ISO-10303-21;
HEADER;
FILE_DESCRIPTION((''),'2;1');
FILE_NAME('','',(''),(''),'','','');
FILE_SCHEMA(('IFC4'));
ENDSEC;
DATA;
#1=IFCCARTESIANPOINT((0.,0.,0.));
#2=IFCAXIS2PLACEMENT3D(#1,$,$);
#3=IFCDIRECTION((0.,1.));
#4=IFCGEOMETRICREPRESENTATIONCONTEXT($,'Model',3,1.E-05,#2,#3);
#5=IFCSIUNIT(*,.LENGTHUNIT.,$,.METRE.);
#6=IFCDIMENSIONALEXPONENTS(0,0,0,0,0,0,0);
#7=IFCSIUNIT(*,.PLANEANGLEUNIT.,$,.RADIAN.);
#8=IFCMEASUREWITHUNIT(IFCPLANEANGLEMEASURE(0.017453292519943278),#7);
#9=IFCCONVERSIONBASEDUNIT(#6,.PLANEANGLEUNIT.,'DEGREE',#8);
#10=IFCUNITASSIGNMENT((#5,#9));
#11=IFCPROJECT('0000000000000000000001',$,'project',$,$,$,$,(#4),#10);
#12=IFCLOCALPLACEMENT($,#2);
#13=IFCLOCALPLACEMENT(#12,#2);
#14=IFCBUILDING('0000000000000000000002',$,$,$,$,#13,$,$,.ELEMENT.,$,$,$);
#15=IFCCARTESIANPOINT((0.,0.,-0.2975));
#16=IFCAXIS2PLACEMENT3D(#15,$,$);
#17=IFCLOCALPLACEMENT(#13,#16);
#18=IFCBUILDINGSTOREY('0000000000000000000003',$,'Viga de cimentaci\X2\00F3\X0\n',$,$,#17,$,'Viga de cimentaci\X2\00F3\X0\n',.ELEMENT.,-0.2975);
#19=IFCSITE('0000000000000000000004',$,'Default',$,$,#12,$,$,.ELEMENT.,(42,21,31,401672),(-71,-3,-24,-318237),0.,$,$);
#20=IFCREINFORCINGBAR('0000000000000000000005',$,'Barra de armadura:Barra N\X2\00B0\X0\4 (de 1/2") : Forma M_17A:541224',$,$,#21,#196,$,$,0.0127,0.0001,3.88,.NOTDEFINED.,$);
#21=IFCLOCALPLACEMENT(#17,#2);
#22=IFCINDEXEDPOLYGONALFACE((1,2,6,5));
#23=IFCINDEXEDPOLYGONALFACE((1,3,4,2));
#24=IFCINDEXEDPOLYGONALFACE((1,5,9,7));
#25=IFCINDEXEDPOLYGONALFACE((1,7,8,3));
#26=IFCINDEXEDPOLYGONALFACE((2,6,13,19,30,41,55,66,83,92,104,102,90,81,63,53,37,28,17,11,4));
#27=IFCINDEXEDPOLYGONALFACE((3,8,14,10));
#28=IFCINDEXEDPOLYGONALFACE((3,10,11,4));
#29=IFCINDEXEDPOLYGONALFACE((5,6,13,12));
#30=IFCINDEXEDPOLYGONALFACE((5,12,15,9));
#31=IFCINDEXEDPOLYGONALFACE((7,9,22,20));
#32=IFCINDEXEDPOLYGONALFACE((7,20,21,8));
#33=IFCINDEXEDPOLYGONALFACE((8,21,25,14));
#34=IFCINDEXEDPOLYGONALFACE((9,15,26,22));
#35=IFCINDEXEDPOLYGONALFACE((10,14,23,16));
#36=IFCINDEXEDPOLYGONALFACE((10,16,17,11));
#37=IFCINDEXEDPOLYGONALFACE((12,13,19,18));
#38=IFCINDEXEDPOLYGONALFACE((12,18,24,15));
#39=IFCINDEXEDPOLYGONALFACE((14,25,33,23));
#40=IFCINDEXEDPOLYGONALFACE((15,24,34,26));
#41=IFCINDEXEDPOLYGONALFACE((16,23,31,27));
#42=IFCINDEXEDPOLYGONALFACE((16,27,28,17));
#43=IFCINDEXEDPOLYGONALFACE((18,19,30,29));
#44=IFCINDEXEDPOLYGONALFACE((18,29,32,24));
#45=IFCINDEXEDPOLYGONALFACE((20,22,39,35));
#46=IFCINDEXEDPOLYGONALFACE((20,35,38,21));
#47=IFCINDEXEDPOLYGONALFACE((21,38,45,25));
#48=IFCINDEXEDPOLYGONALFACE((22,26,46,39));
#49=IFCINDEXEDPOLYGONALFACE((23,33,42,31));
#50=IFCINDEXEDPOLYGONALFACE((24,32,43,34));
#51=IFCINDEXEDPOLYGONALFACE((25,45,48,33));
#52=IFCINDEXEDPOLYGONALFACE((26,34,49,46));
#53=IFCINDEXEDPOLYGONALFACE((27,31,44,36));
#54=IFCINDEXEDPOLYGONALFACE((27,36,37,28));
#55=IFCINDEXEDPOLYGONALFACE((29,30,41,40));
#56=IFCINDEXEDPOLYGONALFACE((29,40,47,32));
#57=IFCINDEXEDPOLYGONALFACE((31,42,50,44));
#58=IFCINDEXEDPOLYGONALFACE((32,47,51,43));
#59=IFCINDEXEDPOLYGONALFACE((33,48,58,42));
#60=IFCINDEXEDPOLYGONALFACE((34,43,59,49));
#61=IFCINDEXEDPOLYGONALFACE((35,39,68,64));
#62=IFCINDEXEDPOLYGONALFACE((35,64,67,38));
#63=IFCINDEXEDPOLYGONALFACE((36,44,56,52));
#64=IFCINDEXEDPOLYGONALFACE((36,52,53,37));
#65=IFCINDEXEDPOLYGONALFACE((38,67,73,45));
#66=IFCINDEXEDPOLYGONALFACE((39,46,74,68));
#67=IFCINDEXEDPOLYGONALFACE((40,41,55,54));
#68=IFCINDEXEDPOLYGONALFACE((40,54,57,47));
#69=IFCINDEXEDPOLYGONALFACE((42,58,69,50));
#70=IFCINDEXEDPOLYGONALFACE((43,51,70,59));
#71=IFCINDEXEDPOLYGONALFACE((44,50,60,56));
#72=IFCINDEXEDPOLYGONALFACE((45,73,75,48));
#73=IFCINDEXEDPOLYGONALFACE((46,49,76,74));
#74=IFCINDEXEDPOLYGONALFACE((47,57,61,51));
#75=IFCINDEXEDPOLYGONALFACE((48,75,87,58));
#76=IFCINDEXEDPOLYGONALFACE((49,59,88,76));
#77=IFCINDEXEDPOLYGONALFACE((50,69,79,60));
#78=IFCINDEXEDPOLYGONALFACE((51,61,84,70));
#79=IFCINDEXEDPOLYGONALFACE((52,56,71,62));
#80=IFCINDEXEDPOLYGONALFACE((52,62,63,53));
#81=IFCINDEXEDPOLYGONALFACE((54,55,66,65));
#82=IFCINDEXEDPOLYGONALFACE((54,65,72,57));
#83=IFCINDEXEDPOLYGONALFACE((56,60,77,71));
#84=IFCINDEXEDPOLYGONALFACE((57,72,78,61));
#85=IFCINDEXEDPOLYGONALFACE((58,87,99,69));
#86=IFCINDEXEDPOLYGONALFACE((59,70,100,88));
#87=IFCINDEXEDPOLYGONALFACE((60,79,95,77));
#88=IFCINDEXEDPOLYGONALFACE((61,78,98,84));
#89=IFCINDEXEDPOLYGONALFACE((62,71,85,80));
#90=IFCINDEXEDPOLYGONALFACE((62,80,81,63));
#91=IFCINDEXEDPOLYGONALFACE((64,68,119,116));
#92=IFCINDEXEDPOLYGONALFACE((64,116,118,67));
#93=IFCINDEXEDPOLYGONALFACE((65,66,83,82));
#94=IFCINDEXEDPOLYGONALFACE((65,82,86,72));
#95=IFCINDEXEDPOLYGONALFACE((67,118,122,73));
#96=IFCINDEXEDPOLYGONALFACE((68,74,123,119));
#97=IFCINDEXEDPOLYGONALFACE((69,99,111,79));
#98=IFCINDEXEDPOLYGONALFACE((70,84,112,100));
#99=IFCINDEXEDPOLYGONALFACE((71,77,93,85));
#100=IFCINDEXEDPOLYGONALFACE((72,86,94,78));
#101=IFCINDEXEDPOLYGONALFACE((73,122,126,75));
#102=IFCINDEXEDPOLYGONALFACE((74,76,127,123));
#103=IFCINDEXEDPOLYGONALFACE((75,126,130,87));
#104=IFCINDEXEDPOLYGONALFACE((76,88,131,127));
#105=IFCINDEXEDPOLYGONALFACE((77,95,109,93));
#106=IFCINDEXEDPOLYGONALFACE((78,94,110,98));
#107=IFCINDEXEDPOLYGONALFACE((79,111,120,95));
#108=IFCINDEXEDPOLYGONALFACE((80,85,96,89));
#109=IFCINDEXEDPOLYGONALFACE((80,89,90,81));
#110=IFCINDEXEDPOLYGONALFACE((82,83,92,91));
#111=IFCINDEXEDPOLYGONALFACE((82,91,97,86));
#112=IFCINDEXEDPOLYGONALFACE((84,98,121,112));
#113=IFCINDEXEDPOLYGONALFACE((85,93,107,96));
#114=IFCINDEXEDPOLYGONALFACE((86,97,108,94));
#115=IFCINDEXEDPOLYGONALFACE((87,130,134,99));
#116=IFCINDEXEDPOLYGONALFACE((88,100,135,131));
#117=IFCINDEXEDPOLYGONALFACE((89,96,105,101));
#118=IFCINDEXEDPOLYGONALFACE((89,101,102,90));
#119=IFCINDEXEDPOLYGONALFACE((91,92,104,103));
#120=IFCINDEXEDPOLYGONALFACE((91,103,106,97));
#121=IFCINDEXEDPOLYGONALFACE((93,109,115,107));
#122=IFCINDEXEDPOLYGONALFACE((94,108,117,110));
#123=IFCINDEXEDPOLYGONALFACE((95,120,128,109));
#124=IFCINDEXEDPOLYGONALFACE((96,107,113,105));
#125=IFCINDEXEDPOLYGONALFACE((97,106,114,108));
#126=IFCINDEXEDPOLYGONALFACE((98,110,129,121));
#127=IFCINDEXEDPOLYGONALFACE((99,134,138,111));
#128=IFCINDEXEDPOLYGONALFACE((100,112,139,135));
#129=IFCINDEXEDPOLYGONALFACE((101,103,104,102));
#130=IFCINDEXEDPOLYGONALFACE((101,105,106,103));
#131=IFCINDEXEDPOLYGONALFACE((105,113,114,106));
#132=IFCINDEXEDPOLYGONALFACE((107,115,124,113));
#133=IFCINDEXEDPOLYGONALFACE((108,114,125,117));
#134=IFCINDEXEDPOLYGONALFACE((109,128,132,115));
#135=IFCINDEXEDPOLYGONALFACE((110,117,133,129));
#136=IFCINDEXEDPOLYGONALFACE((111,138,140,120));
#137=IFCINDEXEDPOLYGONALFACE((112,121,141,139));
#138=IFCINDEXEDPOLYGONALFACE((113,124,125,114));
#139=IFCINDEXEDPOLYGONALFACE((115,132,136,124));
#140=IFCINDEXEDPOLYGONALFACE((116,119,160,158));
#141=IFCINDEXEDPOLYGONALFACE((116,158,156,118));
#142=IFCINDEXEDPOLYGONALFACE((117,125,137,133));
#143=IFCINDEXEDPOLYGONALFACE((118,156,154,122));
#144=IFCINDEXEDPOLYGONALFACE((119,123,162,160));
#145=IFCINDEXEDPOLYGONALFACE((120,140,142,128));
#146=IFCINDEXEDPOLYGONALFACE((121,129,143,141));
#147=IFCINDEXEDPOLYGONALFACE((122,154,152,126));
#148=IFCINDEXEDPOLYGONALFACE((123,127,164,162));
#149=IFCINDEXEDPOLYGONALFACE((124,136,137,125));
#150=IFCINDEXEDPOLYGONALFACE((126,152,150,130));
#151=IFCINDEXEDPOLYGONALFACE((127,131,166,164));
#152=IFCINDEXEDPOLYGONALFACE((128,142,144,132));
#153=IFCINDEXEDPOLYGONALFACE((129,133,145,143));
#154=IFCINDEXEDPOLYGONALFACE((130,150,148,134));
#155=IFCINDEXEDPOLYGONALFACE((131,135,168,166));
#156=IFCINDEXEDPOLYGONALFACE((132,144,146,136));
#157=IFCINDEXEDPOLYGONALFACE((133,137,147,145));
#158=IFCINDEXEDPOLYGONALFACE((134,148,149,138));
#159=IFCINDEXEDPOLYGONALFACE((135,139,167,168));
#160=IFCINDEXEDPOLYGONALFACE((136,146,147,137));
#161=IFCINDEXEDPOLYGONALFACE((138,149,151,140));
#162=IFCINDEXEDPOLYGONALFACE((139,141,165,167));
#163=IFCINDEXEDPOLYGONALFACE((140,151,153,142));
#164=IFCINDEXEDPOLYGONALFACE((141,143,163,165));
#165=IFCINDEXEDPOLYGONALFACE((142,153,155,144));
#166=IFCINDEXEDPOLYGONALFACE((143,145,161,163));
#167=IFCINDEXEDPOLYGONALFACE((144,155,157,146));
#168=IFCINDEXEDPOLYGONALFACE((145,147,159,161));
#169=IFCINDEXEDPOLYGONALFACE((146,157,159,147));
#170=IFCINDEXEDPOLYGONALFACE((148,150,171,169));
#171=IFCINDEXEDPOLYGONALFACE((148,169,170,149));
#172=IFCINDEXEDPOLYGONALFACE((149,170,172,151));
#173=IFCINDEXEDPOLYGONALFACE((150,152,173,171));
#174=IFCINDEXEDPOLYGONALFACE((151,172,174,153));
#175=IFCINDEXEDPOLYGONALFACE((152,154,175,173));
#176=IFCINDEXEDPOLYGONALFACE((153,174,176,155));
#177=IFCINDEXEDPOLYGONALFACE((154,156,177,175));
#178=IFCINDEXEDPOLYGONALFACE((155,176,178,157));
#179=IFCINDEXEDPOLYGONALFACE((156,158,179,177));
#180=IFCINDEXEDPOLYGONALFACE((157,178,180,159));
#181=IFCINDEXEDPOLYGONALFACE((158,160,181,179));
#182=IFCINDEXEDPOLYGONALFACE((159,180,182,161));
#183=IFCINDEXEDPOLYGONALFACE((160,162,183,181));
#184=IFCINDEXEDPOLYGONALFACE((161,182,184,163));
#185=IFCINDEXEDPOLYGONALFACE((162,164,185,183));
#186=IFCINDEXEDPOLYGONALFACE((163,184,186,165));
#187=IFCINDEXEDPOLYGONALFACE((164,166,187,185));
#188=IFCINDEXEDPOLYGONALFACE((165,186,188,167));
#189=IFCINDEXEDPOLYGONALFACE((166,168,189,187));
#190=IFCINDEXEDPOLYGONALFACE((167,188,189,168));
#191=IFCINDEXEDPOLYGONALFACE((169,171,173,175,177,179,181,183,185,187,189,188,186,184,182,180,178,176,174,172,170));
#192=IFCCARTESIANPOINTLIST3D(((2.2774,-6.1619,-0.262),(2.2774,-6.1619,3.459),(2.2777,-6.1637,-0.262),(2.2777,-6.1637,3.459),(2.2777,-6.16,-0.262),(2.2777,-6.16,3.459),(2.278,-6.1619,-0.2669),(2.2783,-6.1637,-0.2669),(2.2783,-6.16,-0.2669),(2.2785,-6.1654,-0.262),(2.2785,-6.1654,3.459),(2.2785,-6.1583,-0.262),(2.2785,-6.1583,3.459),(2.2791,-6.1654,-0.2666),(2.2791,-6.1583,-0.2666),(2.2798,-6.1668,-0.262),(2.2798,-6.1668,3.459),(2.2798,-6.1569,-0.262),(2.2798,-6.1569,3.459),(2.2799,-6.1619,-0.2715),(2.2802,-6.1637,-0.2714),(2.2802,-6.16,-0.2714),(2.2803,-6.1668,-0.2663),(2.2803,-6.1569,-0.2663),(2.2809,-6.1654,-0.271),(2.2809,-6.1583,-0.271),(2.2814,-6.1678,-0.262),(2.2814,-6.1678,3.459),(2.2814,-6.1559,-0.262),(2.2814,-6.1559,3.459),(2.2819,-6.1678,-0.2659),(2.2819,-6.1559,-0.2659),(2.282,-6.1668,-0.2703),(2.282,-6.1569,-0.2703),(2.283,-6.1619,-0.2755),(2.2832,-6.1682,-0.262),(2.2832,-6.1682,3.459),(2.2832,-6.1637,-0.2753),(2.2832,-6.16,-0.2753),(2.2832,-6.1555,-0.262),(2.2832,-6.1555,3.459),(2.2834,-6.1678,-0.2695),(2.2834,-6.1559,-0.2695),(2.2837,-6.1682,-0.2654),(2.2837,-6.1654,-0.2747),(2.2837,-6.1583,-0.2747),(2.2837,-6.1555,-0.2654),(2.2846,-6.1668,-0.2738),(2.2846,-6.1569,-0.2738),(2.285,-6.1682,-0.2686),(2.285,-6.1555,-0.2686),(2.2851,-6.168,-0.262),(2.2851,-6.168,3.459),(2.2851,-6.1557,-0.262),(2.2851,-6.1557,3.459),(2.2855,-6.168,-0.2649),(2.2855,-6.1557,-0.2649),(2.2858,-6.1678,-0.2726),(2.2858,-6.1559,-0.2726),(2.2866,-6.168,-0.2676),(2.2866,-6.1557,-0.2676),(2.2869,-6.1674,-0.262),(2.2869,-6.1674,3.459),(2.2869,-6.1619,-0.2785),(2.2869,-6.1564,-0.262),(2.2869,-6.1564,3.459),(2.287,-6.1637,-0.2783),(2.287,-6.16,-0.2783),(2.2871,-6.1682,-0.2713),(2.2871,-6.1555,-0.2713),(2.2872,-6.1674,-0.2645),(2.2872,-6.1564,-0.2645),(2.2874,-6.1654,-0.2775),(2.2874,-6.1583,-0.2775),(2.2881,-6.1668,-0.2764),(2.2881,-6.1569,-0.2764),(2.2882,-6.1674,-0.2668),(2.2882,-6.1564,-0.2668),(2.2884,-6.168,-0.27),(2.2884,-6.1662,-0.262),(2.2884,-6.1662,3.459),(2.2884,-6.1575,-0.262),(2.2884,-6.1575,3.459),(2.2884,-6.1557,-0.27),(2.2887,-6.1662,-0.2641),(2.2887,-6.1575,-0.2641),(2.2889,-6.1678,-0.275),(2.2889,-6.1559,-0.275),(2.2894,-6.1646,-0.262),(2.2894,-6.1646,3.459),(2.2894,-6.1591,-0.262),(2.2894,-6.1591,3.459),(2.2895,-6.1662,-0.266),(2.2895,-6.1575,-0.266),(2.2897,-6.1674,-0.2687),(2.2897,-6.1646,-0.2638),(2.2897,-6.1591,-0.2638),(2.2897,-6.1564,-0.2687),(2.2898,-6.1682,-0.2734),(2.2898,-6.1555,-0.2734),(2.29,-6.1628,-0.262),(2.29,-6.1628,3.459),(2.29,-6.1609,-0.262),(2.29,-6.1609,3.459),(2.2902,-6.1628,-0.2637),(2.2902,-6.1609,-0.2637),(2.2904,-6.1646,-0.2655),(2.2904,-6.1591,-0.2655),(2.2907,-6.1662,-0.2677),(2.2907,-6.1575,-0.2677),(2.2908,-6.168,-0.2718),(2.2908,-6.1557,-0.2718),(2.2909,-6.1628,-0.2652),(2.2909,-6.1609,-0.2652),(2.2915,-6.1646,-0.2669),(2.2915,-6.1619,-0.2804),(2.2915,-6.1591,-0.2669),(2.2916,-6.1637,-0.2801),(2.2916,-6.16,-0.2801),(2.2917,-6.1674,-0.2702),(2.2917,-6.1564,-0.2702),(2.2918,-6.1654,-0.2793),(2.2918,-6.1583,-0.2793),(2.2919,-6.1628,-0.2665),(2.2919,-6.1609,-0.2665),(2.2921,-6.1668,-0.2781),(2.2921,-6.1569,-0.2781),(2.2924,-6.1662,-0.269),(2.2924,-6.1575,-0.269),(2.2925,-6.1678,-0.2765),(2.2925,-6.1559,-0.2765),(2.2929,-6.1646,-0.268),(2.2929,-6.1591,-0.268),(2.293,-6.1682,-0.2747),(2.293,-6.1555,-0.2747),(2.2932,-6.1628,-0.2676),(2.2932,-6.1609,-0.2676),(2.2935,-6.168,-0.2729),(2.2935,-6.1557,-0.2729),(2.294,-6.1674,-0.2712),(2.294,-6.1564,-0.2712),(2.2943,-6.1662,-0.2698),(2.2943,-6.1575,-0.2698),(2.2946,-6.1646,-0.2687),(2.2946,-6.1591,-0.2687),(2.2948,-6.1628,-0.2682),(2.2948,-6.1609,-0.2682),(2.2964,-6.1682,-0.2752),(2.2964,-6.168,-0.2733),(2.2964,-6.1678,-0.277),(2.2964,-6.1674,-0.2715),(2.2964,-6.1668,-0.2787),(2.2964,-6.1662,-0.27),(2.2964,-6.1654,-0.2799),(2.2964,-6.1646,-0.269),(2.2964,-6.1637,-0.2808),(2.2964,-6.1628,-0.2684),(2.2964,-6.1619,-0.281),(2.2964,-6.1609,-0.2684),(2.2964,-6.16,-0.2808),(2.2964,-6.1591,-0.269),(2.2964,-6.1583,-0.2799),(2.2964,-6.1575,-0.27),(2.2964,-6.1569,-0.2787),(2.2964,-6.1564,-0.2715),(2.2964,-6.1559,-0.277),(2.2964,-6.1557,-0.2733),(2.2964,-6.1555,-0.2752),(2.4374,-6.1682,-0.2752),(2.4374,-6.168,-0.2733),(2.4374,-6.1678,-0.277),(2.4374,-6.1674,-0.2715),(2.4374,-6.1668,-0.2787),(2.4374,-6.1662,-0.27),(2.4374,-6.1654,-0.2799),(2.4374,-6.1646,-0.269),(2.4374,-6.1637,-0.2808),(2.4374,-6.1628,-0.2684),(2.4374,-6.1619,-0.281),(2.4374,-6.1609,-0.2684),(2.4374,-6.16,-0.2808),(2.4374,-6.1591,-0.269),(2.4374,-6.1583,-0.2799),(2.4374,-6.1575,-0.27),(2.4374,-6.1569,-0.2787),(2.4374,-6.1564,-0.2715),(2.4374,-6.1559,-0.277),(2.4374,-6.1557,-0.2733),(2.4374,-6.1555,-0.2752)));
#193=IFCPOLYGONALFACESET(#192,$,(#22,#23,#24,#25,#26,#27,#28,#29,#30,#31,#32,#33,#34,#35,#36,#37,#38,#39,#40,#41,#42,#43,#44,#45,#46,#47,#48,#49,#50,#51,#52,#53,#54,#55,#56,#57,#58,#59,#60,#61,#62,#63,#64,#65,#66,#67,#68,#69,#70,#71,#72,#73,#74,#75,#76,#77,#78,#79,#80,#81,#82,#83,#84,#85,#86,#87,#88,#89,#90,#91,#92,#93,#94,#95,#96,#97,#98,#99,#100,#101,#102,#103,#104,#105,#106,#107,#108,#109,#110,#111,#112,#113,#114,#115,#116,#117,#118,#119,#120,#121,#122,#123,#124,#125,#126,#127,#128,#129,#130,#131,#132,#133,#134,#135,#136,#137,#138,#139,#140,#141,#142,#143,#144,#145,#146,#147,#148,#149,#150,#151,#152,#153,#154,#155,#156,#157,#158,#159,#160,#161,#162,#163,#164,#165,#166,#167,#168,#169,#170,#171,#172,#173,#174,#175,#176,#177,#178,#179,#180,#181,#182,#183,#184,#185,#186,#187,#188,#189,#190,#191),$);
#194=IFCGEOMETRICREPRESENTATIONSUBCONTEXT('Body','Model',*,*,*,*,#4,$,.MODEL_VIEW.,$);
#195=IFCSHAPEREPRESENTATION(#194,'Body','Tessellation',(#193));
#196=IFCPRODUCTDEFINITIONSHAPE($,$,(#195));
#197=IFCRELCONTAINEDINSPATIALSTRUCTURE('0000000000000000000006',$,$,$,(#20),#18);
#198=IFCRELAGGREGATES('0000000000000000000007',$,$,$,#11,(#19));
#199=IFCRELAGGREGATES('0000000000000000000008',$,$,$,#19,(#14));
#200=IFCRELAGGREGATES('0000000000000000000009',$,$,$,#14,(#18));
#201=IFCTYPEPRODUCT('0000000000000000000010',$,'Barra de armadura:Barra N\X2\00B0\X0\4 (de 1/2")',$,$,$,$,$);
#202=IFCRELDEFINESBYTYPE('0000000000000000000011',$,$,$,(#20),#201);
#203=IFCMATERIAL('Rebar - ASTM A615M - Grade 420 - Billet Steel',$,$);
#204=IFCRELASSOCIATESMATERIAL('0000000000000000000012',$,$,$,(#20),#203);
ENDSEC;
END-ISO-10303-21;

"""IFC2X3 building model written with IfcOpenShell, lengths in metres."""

from ifc_helpers import new_model, entity, si_unit, converted_unit, direction, frame, origin, place, context, subcontext, project, spatial, material, type_object, element, save


model = new_model("IFC2X3")

# Units and contexts
model_context = context("Model", 3, precision=1e-05, world=origin(), true_north=direction((0.0, 1.0)))
body_context = subcontext(model_context, "Body", "Model", "MODEL_VIEW")
ifc_project = project(units=[si_unit("LENGTHUNIT", "METRE"), converted_unit("PLANEANGLEUNIT", "DEGREE", entity("IfcPlaneAngleMeasure", 0.017453292519943278), si_unit("PLANEANGLEUNIT", "RADIAN"), dimensions=[0, 0, 0, 0, 0, 0, 0])], contexts=[model_context])

# Site, building, storey
site_placement = place(None, origin())
site = spatial("IfcSite", under=ifc_project, at=site_placement, Name="Default", CompositionType="ELEMENT", RefLatitude=(42, 21, 31, 401672), RefLongitude=(-71, -3, -24, -318237), RefElevation=0.0)
building_placement = place(site_placement, origin())
building = spatial("IfcBuilding", under=site, at=building_placement, CompositionType="ELEMENT")
storey_placement = place(building_placement, frame((0.0, 0.0, -0.2975)))
storey = spatial("IfcBuildingStorey", under=building, at=storey_placement, Name="Viga de cimentación", LongName="Viga de cimentación", CompositionType="ELEMENT", Elevation=-0.2975)

# Reinforcing bar
ifc_material_1 = material(Name="Rebar - ASTM A615M - Grade 420 - Billet Steel")
type_product_1 = type_object("IfcTypeProduct", Name="Barra de armadura:Barra N°4 (de 1/2\")")
reinforcing_bar_1_placement = place(storey_placement, origin())
element("IfcReinforcingBar", 1, at=reinforcing_bar_1_placement, inside=storey, type_object=type_product_1, material=ifc_material_1, Name="Barra de armadura:Barra N°4 (de 1/2\") : Forma M_17A:541224", BarLength=3.88, BarRole="NOTDEFINED", CrossSectionArea=0.0001, NominalDiameter=0.0127, context=body_context, shape_type="AdvancedSweptSolid", body=[
    entity("IfcSweptDiskSolid", entity("IfcCompositeCurve", [entity("IfcCompositeCurveSegment", "CONTINUOUS", True, entity("IfcPolyline", [entity("IfcCartesianPoint", [2.2837, -6.1619, 3.459]), entity("IfcCartesianPoint", [2.2837, -6.1619, -0.262])])), entity("IfcCompositeCurveSegment", "CONTINUOUS", True, entity("IfcTrimmedCurve", entity("IfcCircle", entity("IfcAxis2Placement3D", entity("IfcCartesianPoint", [2.2964, -6.1619, -0.262]), entity("IfcDirection", [0.0, -1.0, 0.0]), entity("IfcDirection", [0.0, 0.0, -1.0])), 0.0127), [entity("IfcParameterValue", 270.0)], [entity("IfcParameterValue", 360.0)], True, "PARAMETER")), entity("IfcCompositeCurveSegment", "CONTINUOUS", True, entity("IfcPolyline", [entity("IfcCartesianPoint", [2.2964, -6.1619, -0.2747]), entity("IfcCartesianPoint", [2.4374, -6.1619, -0.2747])]))], False), 0.0063, None, 0.0, 92.0),
])

save(model, "model.ifc")
